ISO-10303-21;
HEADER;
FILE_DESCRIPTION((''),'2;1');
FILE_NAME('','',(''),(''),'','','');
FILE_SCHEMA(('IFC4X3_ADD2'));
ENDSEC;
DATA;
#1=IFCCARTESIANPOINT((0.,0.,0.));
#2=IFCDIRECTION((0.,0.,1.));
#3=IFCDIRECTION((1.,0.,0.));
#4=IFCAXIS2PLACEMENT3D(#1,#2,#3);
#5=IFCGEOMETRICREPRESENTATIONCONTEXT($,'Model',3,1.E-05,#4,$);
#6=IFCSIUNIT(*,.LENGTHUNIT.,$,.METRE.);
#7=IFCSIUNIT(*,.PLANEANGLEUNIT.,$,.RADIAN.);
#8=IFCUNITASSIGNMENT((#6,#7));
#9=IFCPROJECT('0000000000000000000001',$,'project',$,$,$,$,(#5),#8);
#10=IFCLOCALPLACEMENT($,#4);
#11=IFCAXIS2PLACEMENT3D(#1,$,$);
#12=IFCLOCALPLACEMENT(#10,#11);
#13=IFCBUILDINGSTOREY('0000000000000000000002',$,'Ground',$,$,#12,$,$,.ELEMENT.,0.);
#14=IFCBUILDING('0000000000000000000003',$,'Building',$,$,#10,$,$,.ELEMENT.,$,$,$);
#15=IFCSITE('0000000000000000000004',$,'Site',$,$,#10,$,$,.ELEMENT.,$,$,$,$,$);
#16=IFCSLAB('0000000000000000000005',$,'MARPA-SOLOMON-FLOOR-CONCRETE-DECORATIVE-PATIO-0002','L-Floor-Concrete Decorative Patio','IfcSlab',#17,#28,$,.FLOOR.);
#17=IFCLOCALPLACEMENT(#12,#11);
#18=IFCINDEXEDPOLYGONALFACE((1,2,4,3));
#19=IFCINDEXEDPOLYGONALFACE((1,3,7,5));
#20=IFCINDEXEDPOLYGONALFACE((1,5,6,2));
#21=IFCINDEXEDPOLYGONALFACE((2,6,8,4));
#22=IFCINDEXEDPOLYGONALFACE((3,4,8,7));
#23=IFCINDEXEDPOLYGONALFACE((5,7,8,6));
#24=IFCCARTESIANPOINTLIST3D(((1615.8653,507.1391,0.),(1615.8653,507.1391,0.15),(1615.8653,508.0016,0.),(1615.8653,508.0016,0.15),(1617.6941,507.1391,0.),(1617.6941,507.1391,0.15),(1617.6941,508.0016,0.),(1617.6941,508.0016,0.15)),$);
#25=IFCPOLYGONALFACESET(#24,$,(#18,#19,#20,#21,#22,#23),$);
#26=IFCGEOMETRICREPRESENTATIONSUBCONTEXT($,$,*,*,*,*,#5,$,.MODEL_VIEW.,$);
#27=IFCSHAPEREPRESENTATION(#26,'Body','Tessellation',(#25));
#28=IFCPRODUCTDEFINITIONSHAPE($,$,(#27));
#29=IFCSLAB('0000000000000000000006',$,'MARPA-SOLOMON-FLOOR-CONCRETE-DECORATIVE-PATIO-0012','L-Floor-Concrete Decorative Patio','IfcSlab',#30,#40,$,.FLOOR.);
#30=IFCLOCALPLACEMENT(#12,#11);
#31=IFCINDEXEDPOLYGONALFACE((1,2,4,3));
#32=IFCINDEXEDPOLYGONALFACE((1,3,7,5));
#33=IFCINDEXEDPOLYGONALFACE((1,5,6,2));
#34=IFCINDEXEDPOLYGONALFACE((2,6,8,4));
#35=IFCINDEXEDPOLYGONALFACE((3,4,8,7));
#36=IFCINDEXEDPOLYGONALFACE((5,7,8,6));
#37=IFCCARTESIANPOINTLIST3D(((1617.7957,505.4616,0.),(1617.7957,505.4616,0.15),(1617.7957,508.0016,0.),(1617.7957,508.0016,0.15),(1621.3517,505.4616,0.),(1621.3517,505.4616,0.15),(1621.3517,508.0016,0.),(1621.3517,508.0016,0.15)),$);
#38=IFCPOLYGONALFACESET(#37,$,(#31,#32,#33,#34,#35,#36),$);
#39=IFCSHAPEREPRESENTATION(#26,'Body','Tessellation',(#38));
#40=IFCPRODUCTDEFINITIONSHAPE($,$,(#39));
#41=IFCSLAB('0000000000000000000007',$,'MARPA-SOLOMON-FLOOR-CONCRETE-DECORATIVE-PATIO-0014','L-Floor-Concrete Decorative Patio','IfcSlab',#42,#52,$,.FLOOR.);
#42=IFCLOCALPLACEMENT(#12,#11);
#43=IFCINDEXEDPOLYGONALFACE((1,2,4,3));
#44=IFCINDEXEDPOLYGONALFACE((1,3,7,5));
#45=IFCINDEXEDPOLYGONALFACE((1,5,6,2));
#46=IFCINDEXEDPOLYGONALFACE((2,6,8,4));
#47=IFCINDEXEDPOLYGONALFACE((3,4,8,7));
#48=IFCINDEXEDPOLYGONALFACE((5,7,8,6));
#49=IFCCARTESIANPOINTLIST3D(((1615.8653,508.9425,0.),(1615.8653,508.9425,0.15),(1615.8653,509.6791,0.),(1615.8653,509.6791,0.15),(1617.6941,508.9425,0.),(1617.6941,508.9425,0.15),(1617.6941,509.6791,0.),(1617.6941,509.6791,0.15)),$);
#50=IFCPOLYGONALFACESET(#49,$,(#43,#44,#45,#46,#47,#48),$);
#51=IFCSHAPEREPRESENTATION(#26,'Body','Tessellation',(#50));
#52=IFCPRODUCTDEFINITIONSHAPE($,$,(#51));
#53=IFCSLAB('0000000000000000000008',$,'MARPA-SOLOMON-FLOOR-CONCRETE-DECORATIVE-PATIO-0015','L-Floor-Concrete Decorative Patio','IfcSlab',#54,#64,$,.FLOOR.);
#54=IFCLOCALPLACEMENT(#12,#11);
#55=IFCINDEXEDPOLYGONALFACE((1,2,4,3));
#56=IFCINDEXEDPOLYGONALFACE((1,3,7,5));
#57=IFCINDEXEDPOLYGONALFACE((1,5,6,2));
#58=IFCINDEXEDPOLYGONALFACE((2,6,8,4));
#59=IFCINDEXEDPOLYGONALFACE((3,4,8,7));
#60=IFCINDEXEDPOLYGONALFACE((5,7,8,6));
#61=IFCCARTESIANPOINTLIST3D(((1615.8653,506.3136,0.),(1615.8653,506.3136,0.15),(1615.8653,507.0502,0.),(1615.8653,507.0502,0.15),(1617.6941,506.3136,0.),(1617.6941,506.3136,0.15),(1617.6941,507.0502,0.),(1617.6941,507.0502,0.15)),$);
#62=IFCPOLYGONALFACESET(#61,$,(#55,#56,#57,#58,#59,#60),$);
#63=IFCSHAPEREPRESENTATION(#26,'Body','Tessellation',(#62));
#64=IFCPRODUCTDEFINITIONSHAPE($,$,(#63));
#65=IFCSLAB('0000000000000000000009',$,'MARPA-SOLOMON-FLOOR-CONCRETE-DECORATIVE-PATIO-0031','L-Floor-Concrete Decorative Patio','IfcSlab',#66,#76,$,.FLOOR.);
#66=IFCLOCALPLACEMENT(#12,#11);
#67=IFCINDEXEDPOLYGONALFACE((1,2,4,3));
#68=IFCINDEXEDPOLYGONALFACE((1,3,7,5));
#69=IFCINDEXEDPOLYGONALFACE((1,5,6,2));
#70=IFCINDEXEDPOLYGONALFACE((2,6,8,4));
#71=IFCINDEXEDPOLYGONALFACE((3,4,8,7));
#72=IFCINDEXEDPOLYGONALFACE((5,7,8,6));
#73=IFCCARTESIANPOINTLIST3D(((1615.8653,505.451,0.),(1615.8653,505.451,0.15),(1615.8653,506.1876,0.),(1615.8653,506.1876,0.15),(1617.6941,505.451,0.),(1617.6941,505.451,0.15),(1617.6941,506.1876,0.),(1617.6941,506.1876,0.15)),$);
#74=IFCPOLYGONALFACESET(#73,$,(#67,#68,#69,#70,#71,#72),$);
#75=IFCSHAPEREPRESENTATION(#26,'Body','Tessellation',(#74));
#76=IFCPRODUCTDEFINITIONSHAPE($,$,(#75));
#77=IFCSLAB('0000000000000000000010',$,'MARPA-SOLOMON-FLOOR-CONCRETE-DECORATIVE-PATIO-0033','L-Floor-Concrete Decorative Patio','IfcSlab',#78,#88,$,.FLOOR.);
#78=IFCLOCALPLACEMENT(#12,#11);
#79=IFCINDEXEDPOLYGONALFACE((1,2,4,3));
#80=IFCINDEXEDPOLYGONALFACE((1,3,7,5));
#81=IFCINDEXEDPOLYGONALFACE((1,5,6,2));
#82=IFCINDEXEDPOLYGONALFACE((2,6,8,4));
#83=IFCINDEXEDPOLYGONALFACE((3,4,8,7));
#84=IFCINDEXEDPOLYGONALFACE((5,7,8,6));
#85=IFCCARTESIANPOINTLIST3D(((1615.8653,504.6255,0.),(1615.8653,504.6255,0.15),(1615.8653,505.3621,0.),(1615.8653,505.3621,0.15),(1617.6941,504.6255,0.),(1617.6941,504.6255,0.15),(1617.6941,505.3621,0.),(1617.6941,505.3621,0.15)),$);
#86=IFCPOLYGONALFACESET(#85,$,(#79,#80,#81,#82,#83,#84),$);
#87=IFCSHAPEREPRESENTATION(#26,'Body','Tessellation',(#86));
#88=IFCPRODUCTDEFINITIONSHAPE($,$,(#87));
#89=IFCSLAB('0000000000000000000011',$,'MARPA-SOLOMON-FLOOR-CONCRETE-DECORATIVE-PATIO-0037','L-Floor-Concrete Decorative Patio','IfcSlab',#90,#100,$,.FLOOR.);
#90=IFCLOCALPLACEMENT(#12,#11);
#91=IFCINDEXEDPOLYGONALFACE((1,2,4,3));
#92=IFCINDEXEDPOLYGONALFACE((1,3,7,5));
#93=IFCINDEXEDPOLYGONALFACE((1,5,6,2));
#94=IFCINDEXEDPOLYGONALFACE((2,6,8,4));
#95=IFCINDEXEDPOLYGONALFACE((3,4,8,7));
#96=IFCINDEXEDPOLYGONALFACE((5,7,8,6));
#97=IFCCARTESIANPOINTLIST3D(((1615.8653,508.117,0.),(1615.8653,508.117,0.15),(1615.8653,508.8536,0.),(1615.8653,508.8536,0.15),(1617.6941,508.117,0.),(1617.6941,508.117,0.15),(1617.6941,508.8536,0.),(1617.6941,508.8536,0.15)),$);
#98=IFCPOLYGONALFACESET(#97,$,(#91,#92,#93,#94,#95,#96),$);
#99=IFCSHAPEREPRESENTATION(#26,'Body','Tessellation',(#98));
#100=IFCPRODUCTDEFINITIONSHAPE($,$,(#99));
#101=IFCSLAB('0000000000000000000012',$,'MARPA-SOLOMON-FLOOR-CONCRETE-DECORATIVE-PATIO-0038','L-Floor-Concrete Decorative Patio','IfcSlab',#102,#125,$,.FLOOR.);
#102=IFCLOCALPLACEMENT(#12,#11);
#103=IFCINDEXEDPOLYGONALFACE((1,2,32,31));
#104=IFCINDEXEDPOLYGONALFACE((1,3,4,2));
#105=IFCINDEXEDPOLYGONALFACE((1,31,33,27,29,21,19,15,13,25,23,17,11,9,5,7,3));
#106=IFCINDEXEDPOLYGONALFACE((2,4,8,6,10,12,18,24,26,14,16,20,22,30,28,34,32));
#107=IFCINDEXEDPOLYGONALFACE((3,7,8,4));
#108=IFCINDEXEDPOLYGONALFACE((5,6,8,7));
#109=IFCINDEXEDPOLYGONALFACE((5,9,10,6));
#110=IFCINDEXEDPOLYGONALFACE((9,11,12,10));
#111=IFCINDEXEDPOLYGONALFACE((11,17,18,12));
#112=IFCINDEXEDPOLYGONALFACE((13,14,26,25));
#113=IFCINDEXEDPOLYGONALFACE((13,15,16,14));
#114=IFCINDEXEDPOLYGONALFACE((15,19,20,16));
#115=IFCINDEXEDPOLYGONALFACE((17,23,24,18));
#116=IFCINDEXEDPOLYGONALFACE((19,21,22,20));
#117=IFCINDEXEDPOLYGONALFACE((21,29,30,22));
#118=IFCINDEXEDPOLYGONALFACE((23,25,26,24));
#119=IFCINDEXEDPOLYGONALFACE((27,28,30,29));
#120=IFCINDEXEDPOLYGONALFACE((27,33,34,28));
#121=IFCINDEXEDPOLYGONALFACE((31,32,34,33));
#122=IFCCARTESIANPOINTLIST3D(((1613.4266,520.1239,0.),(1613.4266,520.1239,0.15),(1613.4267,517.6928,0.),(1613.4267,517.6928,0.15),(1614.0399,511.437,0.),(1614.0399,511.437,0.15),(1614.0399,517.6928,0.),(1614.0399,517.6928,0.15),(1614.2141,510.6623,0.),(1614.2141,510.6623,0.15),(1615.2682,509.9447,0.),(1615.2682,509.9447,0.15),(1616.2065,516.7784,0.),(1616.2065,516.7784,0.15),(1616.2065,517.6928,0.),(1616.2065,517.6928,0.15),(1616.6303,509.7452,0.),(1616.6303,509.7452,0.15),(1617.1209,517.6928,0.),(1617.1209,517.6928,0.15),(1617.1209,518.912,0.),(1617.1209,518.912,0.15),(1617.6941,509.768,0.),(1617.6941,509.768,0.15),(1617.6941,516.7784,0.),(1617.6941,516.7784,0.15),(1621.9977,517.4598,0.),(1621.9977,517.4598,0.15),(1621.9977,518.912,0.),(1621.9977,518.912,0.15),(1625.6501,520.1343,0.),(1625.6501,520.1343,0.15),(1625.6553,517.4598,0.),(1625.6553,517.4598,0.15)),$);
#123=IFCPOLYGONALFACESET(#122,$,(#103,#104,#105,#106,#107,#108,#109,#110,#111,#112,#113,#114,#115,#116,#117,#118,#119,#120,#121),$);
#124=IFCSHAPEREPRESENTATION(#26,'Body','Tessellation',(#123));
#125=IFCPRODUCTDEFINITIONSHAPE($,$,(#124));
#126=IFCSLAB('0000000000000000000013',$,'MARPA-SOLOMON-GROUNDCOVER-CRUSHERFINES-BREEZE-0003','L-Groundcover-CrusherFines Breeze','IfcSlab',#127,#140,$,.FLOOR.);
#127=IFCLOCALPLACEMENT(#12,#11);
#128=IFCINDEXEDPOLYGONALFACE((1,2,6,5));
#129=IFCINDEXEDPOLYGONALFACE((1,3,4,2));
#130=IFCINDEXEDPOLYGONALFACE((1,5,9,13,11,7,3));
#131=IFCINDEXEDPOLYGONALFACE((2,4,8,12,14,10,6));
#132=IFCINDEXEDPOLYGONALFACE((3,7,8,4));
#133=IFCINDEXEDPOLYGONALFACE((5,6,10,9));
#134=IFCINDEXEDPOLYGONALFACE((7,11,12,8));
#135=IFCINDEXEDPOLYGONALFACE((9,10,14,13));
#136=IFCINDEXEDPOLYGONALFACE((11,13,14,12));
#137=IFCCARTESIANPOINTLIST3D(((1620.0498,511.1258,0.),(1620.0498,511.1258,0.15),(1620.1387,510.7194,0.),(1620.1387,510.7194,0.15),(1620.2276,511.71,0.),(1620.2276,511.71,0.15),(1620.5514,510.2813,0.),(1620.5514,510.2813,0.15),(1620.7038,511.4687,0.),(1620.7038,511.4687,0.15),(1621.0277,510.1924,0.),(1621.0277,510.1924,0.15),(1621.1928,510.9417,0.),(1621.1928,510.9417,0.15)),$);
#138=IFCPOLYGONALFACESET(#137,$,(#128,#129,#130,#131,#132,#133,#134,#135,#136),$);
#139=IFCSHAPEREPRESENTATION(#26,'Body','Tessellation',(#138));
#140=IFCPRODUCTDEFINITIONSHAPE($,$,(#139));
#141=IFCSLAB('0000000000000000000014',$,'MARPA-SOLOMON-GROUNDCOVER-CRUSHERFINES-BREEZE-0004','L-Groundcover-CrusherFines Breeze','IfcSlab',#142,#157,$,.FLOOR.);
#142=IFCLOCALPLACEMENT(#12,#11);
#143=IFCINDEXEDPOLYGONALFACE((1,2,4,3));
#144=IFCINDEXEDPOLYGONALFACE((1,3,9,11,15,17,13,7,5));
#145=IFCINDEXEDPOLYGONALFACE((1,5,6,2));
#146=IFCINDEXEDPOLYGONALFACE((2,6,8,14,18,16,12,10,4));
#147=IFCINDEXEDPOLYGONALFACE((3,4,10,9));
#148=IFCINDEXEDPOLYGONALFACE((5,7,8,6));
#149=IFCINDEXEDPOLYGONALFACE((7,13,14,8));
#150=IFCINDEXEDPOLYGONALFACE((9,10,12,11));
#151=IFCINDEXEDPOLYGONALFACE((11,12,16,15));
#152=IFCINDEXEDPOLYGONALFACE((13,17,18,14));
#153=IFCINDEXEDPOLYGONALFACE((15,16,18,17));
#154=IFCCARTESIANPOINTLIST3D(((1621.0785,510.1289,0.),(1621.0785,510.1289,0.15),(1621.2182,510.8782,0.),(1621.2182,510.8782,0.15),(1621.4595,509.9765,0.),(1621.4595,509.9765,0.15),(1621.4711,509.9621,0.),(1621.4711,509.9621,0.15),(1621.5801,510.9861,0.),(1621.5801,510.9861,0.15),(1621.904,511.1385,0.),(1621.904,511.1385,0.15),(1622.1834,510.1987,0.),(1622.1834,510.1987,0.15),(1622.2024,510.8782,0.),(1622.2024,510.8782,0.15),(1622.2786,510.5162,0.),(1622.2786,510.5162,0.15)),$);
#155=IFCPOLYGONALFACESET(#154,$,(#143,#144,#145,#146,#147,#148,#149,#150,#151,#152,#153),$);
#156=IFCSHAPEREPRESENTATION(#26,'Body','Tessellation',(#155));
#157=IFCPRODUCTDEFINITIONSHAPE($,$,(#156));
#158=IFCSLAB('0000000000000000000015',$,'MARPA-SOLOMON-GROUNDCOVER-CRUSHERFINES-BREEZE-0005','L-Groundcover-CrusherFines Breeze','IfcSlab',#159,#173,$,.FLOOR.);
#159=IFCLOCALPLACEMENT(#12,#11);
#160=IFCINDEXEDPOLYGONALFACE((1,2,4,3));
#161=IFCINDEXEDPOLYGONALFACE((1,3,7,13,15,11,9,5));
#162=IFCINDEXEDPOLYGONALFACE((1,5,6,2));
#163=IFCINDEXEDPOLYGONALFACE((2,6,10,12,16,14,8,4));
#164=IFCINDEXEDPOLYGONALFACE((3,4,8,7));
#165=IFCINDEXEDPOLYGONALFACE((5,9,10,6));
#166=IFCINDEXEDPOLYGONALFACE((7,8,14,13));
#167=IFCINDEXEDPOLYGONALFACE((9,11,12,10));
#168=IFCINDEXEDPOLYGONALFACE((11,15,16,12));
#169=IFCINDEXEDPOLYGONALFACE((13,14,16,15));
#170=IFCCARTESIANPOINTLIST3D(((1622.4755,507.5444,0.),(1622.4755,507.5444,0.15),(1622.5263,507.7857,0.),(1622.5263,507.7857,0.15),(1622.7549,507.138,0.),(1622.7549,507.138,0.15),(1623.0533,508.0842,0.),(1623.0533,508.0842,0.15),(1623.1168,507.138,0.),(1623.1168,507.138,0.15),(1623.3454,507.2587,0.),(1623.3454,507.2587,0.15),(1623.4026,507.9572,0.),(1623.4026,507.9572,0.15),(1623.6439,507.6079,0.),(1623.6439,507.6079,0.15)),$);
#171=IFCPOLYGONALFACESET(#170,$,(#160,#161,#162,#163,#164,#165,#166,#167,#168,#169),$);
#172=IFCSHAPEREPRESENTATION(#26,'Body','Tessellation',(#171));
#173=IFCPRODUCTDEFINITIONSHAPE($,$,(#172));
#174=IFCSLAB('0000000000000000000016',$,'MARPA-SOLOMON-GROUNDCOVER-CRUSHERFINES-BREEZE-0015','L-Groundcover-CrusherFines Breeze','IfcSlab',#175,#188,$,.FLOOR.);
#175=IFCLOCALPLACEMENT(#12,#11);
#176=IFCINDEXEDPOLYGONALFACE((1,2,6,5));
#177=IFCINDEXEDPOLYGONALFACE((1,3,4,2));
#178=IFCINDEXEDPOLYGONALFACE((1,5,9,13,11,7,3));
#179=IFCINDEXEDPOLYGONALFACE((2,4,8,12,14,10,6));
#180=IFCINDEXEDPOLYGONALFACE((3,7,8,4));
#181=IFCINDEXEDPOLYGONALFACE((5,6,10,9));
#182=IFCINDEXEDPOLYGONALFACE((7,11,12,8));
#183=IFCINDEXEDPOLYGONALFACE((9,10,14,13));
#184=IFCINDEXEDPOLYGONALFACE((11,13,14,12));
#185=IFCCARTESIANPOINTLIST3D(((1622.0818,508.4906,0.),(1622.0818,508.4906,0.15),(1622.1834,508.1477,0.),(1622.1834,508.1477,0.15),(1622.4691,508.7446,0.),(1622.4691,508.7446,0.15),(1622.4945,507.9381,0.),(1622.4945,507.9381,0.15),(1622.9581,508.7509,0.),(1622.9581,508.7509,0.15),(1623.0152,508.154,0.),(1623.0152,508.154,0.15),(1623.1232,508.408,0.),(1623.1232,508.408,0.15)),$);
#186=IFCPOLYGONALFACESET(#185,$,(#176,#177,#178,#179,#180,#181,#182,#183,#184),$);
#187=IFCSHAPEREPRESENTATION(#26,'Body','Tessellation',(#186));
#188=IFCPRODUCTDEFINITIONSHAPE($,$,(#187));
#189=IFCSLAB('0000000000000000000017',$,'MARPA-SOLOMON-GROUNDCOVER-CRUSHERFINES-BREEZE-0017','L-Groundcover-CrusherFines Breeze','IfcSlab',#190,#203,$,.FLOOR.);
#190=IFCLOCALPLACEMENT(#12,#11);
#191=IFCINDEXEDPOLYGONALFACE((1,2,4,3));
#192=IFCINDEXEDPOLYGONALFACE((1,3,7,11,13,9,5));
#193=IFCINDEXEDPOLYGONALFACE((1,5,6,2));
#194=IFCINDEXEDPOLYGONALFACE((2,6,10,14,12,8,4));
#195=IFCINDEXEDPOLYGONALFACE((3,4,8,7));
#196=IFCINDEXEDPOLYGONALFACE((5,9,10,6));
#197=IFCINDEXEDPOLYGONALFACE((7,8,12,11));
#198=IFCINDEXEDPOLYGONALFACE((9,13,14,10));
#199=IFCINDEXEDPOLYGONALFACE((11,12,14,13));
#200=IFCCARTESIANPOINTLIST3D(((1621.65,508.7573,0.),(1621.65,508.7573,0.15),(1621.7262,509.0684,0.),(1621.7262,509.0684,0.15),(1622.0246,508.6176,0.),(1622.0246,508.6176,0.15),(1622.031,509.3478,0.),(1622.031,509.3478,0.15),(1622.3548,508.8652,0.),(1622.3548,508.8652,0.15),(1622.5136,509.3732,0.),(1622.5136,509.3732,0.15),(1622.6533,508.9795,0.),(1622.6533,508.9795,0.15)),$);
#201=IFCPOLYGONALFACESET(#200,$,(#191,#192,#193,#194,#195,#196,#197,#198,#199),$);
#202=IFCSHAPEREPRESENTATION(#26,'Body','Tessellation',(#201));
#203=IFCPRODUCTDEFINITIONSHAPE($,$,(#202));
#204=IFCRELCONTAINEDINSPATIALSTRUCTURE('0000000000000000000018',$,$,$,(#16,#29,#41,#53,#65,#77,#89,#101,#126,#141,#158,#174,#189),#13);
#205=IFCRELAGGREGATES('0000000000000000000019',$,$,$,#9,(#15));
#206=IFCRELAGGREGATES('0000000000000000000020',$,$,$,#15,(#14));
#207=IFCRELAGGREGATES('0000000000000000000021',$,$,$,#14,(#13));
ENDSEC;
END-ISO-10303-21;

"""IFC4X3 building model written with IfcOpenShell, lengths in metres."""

from ifc_helpers import new_model, si_unit, frame, origin, origin_with_axes, place, context, subcontext, project, spatial, polyline, outline, extrude, element, save


model = new_model("IFC4X3")

# Units and contexts
model_context = context("Model", 3, precision=1e-05, world=origin_with_axes())
sub_context = subcontext(model_context, None, None, "MODEL_VIEW")
ifc_project = project(units=[si_unit("LENGTHUNIT", "METRE"), si_unit("PLANEANGLEUNIT", "RADIAN")], contexts=[model_context])

# Site, building, storey
placement = place(None, origin_with_axes())
site = spatial("IfcSite", under=ifc_project, at=placement, Name="Site", CompositionType="ELEMENT")
building = spatial("IfcBuilding", under=site, at=placement, Name="Building", CompositionType="ELEMENT")
storey_placement = place(placement, origin())
storey = spatial("IfcBuildingStorey", under=building, at=storey_placement, Name="Ground", CompositionType="ELEMENT", Elevation=0.0)

# Slabs
slab_1_placement = place(storey_placement, frame((1615.8653, 507.1391, 0.0)))
element("IfcSlab", 1, at=slab_1_placement, inside=storey, Name="MARPA-SOLOMON-FLOOR-CONCRETE-DECORATIVE-PATIO-0002", Description="L-Floor-Concrete Decorative Patio", ObjectType="IfcSlab", PredefinedType="FLOOR", context=sub_context, shape_type="SweptSolid", body=[
    extrude(outline(polyline([(0.0, 0.8626), (1.8288, 0.8626), (1.8288, 0.0), (0.0, 0.0), (0.0, 0.8626)])), origin(), (0.0, 0.0, 1.0), 0.15),
])
slab_2_placement = place(storey_placement, frame((1617.7957, 505.4616, 0.0)))
element("IfcSlab", 2, at=slab_2_placement, inside=storey, Name="MARPA-SOLOMON-FLOOR-CONCRETE-DECORATIVE-PATIO-0012", Description="L-Floor-Concrete Decorative Patio", ObjectType="IfcSlab", PredefinedType="FLOOR", context=sub_context, shape_type="SweptSolid", body=[
    extrude(outline(polyline([(0.0, 2.54), (0.0, 0.0), (3.556, 0.0), (3.556, 2.54), (0.0, 2.54)])), origin(), (0.0, 0.0, 1.0), 0.15),
])
slab_3_placement = place(storey_placement, frame((1615.8653, 508.9425, 0.0)))
element("IfcSlab", 3, at=slab_3_placement, inside=storey, Name="MARPA-SOLOMON-FLOOR-CONCRETE-DECORATIVE-PATIO-0014", Description="L-Floor-Concrete Decorative Patio", ObjectType="IfcSlab", PredefinedType="FLOOR", context=sub_context, shape_type="SweptSolid", body=[
    extrude(outline(polyline([(0.0, 0.7366), (1.8288, 0.7366), (1.8288, 0.0), (0.0, 0.0), (0.0, 0.7366)])), origin(), (0.0, 0.0, 1.0), 0.15),
])
slab_4_placement = place(storey_placement, frame((1615.8653, 506.3136, 0.0)))
element("IfcSlab", 4, at=slab_4_placement, inside=storey, Name="MARPA-SOLOMON-FLOOR-CONCRETE-DECORATIVE-PATIO-0015", Description="L-Floor-Concrete Decorative Patio", ObjectType="IfcSlab", PredefinedType="FLOOR", context=sub_context, shape_type="SweptSolid", body=[
    extrude(outline(polyline([(0.0, 0.7366), (1.8288, 0.7366), (1.8288, 0.0), (0.0, 0.0), (0.0, 0.7366)])), origin(), (0.0, 0.0, 1.0), 0.15),
])
slab_5_placement = place(storey_placement, frame((1615.8653, 505.451, 0.0)))
element("IfcSlab", 5, at=slab_5_placement, inside=storey, Name="MARPA-SOLOMON-FLOOR-CONCRETE-DECORATIVE-PATIO-0031", Description="L-Floor-Concrete Decorative Patio", ObjectType="IfcSlab", PredefinedType="FLOOR", context=sub_context, shape_type="SweptSolid", body=[
    extrude(outline(polyline([(0.0, 0.7366), (1.8288, 0.7366), (1.8288, 0.0), (0.0, 0.0), (0.0, 0.7366)])), origin(), (0.0, 0.0, 1.0), 0.15),
])
slab_6_placement = place(storey_placement, frame((1615.8653, 504.6255, 0.0)))
element("IfcSlab", 6, at=slab_6_placement, inside=storey, Name="MARPA-SOLOMON-FLOOR-CONCRETE-DECORATIVE-PATIO-0033", Description="L-Floor-Concrete Decorative Patio", ObjectType="IfcSlab", PredefinedType="FLOOR", context=sub_context, shape_type="SweptSolid", body=[
    extrude(outline(polyline([(0.0, 0.7366), (1.8288, 0.7366), (1.8288, 0.0), (0.0, 0.0), (0.0, 0.7366)])), origin(), (0.0, 0.0, 1.0), 0.15),
])
slab_7_placement = place(storey_placement, frame((1615.8653, 508.117, 0.0)))
element("IfcSlab", 7, at=slab_7_placement, inside=storey, Name="MARPA-SOLOMON-FLOOR-CONCRETE-DECORATIVE-PATIO-0037", Description="L-Floor-Concrete Decorative Patio", ObjectType="IfcSlab", PredefinedType="FLOOR", context=sub_context, shape_type="SweptSolid", body=[
    extrude(outline(polyline([(0.0, 0.7366), (1.8288, 0.7366), (1.8288, 0.0), (0.0, 0.0), (0.0, 0.7366)])), origin(), (0.0, 0.0, 1.0), 0.15),
])
slab_8_placement = place(storey_placement, frame((1613.4266, 509.7452, 0.0)))
element("IfcSlab", 8, at=slab_8_placement, inside=storey, Name="MARPA-SOLOMON-FLOOR-CONCRETE-DECORATIVE-PATIO-0038", Description="L-Floor-Concrete Decorative Patio", ObjectType="IfcSlab", PredefinedType="FLOOR", context=sub_context, shape_type="SweptSolid", body=[
    extrude(outline(polyline([(12.2287, 7.7146), (8.5711, 7.7146), (8.5711, 9.1668), (3.6943, 9.1668), (3.6943, 7.9476), (2.7799, 7.9476), (2.7799, 7.0332), (4.2675, 7.0332), (4.2675, 0.0228), (3.2037, 0.0), (1.8416, 0.1995), (0.7875, 0.9171), (0.6133, 1.6918), (0.6133, 7.9476), (0.0001, 7.9476), (0.0, 10.3787), (12.2234, 10.389), (12.2287, 7.7146)])), origin(), (0.0, 0.0, 1.0), 0.15),
])
slab_9_placement = place(storey_placement, frame((1620.0498, 510.1924, 0.0)))
element("IfcSlab", 9, at=slab_9_placement, inside=storey, Name="MARPA-SOLOMON-GROUNDCOVER-CRUSHERFINES-BREEZE-0003", Description="L-Groundcover-CrusherFines Breeze", ObjectType="IfcSlab", PredefinedType="FLOOR", context=sub_context, shape_type="SweptSolid", body=[
    extrude(outline(polyline([(0.0, 0.9334), (0.1778, 1.5176), (0.654, 1.2763), (1.143, 0.7493), (0.9779, 0.0), (0.5016, 0.0889), (0.0889, 0.527), (0.0, 0.9334)])), origin(), (0.0, 0.0, 1.0), 0.15),
])
slab_10_placement = place(storey_placement, frame((1621.0785, 509.9621, 0.0)))
element("IfcSlab", 10, at=slab_10_placement, inside=storey, Name="MARPA-SOLOMON-GROUNDCOVER-CRUSHERFINES-BREEZE-0004", Description="L-Groundcover-CrusherFines Breeze", ObjectType="IfcSlab", PredefinedType="FLOOR", context=sub_context, shape_type="SweptSolid", body=[
    extrude(outline(polyline([(0.381, 0.0144), (0.0, 0.1668), (0.1397, 0.9161), (0.5016, 1.024), (0.8255, 1.1764), (1.1239, 0.9161), (1.2001, 0.5541), (1.1049, 0.2366), (0.3926, 0.0), (0.381, 0.0144)])), origin(), (0.0, 0.0, 1.0), 0.15),
])
slab_11_placement = place(storey_placement, frame((1622.4755, 507.138, 0.0)))
element("IfcSlab", 11, at=slab_11_placement, inside=storey, Name="MARPA-SOLOMON-GROUNDCOVER-CRUSHERFINES-BREEZE-0005", Description="L-Groundcover-CrusherFines Breeze", ObjectType="IfcSlab", PredefinedType="FLOOR", context=sub_context, shape_type="SweptSolid", body=[
    extrude(outline(polyline([(0.6413, 0.0), (0.2794, 0.0), (0.0, 0.4064), (0.0508, 0.6477), (0.5778, 0.9462), (0.9271, 0.8192), (1.1684, 0.4699), (0.87, 0.1207), (0.6413, 0.0)])), origin(), (0.0, 0.0, 1.0), 0.15),
])
slab_12_placement = place(storey_placement, frame((1622.0818, 507.9381, 0.0)))
element("IfcSlab", 12, at=slab_12_placement, inside=storey, Name="MARPA-SOLOMON-GROUNDCOVER-CRUSHERFINES-BREEZE-0015", Description="L-Groundcover-CrusherFines Breeze", ObjectType="IfcSlab", PredefinedType="FLOOR", context=sub_context, shape_type="SweptSolid", body=[
    extrude(outline(polyline([(0.4127, 0.0), (0.1016, 0.2095), (0.0, 0.5524), (0.3873, 0.8064), (0.8763, 0.8128), (1.0414, 0.4699), (0.9334, 0.2159), (0.4127, 0.0)])), origin(), (0.0, 0.0, 1.0), 0.15),
])
slab_13_placement = place(storey_placement, frame((1621.65, 508.6176, 0.0)))
element("IfcSlab", 13, at=slab_13_placement, inside=storey, Name="MARPA-SOLOMON-GROUNDCOVER-CRUSHERFINES-BREEZE-0017", Description="L-Groundcover-CrusherFines Breeze", ObjectType="IfcSlab", PredefinedType="FLOOR", context=sub_context, shape_type="SweptSolid", body=[
    extrude(outline(polyline([(0.3746, 0.0), (0.7048, 0.2477), (1.0033, 0.3619), (0.8636, 0.7557), (0.381, 0.7303), (0.0762, 0.4509), (0.0, 0.1397), (0.3746, 0.0)])), origin(), (0.0, 0.0, 1.0), 0.15),
])

save(model, "model.ifc")
